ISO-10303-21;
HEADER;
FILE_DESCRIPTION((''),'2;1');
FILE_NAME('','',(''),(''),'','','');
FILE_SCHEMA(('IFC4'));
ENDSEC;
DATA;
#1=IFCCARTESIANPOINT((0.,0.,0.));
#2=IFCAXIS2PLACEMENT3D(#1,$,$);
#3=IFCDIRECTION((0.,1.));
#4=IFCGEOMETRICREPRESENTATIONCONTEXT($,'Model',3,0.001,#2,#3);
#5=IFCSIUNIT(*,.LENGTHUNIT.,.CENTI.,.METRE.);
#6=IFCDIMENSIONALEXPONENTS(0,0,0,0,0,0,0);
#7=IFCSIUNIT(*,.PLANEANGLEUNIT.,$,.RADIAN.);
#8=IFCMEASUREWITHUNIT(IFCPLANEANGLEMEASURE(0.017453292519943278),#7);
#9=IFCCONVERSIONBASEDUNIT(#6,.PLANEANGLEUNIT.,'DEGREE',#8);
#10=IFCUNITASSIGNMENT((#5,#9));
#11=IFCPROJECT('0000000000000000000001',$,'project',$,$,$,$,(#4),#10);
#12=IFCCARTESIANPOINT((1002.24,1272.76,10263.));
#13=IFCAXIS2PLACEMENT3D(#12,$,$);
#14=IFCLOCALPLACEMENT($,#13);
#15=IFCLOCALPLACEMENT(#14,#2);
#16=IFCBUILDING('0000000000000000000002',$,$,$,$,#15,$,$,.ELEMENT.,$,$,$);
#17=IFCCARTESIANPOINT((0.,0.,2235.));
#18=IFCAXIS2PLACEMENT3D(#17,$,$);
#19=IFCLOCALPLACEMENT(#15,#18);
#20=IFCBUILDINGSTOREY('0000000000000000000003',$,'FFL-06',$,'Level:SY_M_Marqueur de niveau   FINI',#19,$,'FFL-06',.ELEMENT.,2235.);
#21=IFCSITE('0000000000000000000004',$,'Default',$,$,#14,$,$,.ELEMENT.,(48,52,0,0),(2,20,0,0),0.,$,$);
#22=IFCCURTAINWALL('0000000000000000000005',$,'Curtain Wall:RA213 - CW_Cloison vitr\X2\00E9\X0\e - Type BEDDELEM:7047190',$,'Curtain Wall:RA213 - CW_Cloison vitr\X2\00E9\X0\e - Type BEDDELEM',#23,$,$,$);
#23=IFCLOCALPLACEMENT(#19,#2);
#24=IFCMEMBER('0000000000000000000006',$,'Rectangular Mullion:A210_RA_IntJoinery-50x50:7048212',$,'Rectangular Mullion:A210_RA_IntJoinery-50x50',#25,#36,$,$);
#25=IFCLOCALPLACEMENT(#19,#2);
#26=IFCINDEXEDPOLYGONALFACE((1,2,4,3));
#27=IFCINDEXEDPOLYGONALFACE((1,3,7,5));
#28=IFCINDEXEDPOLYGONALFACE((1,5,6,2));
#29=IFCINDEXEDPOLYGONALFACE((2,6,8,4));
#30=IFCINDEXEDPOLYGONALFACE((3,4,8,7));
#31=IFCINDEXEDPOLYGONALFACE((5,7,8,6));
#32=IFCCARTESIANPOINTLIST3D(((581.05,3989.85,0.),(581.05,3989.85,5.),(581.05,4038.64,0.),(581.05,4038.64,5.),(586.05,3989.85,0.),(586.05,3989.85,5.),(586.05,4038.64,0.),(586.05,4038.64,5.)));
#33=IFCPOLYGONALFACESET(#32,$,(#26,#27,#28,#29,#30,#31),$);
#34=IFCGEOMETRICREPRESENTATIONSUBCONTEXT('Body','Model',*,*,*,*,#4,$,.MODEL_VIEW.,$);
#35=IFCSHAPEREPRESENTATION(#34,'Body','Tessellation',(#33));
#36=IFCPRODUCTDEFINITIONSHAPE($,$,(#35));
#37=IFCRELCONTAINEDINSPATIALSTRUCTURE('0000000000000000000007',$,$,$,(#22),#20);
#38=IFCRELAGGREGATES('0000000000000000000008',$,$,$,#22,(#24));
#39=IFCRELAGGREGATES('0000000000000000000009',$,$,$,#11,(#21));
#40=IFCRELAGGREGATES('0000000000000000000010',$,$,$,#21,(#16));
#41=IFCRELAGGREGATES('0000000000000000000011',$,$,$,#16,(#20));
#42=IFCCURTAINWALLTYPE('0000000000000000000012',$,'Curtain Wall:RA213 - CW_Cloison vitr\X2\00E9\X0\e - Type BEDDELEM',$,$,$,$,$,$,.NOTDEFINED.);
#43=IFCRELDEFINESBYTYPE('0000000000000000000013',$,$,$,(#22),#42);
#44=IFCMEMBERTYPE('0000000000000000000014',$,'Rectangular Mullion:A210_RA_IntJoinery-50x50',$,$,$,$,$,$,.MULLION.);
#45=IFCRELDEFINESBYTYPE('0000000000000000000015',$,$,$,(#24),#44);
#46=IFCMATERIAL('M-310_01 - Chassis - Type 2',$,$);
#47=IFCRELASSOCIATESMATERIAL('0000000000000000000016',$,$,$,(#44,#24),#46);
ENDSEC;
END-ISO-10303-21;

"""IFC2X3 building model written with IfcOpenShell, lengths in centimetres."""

from ifc_helpers import new_model, entity, si_unit, converted_unit, direction, frame, origin, origin_2d_with_axis, place, context, subcontext, project, spatial, rectangle, extrude, source, transform, mapped, material, type_object, type_shapes, element, aggregate, save


model = new_model("IFC2X3")

# Units and contexts
model_context = context("Model", 3, precision=0.001, world=origin(), true_north=direction((0.0, 1.0)))
body_context = subcontext(model_context, "Body", "Model", "MODEL_VIEW")
ifc_project = project(units=[si_unit("LENGTHUNIT", "METRE", prefix="CENTI"), converted_unit("PLANEANGLEUNIT", "DEGREE", entity("IfcPlaneAngleMeasure", 0.017453292519943278), si_unit("PLANEANGLEUNIT", "RADIAN"), dimensions=[0, 0, 0, 0, 0, 0, 0])], contexts=[model_context])

# Site, building, storey
site_placement = place(None, frame((1002.24, 1272.76, 10263.0)))
site = spatial("IfcSite", under=ifc_project, at=site_placement, Name="Default", CompositionType="ELEMENT", RefLatitude=(48, 52, 0, 0), RefLongitude=(2, 20, 0, 0), RefElevation=0.0)
building_placement = place(site_placement, origin())
building = spatial("IfcBuilding", under=site, at=building_placement, CompositionType="ELEMENT")
storey_placement = place(building_placement, frame((0.0, 0.0, 2235.0)))
storey = spatial("IfcBuildingStorey", under=building, at=storey_placement, Name="FFL-06", ObjectType="Level:SY_M_Marqueur de niveau   FINI", LongName="FFL-06", CompositionType="ELEMENT", Elevation=2235.0)

# Curtain wall
curtain_wall_type_1 = type_object("IfcCurtainWallType", Name="Curtain Wall:RA213 - CW_Cloison vitrée - Type BEDDELEM", PredefinedType="NOTDEFINED")
curtain_wall_1_placement = place(storey_placement, frame((0.0, 0.0, -2235.0)))
curtain_wall_1 = element("IfcCurtainWall", 1, at=curtain_wall_1_placement, inside=storey, type_object=curtain_wall_type_1, Name="Curtain Wall:RA213 - CW_Cloison vitrée - Type BEDDELEM:7047190", ObjectType="Curtain Wall:RA213 - CW_Cloison vitrée - Type BEDDELEM")
ifc_material_1 = material(Name="M-310_01 - Chassis - Type 2")

# Member
member_type_1 = type_object("IfcMemberType", Name="Rectangular Mullion:A210_RA_IntJoinery-50x50", PredefinedType="MULLION", material=ifc_material_1)
shared_shape_1 = source(origin(), body_context, "Body", "SweptSolid", [
    extrude(rectangle(XDim=5.0, YDim=5.0, at=origin_2d_with_axis()), frame((-2.5, -2.5, -48.79), z_axis=(0.0, 0.0, 1.0), x_axis=(-1.0, 0.0, 0.0)), (0.0, 0.0, 1.0), 48.79),
])
type_shapes(member_type_1, [shared_shape_1])
member_1_placement = place(curtain_wall_1_placement, frame((581.05, 4038.64, 2235.0), z_axis=(0.0, 1.0, 0.0), x_axis=(0.0, 0.0, -1.0)))
member_1 = element("IfcMember", 2, at=member_1_placement, type_object=member_type_1, material=ifc_material_1, Name="Rectangular Mullion:A210_RA_IntJoinery-50x50:7048212", ObjectType="Rectangular Mullion:A210_RA_IntJoinery-50x50", context=body_context, shape_type="MappedRepresentation", body=[
    mapped(shared_shape_1, transform((0.0, 0.0, 0.0), scale=1.0)),
])

aggregate(curtain_wall_1, [member_1])

save(model, "model.ifc")
